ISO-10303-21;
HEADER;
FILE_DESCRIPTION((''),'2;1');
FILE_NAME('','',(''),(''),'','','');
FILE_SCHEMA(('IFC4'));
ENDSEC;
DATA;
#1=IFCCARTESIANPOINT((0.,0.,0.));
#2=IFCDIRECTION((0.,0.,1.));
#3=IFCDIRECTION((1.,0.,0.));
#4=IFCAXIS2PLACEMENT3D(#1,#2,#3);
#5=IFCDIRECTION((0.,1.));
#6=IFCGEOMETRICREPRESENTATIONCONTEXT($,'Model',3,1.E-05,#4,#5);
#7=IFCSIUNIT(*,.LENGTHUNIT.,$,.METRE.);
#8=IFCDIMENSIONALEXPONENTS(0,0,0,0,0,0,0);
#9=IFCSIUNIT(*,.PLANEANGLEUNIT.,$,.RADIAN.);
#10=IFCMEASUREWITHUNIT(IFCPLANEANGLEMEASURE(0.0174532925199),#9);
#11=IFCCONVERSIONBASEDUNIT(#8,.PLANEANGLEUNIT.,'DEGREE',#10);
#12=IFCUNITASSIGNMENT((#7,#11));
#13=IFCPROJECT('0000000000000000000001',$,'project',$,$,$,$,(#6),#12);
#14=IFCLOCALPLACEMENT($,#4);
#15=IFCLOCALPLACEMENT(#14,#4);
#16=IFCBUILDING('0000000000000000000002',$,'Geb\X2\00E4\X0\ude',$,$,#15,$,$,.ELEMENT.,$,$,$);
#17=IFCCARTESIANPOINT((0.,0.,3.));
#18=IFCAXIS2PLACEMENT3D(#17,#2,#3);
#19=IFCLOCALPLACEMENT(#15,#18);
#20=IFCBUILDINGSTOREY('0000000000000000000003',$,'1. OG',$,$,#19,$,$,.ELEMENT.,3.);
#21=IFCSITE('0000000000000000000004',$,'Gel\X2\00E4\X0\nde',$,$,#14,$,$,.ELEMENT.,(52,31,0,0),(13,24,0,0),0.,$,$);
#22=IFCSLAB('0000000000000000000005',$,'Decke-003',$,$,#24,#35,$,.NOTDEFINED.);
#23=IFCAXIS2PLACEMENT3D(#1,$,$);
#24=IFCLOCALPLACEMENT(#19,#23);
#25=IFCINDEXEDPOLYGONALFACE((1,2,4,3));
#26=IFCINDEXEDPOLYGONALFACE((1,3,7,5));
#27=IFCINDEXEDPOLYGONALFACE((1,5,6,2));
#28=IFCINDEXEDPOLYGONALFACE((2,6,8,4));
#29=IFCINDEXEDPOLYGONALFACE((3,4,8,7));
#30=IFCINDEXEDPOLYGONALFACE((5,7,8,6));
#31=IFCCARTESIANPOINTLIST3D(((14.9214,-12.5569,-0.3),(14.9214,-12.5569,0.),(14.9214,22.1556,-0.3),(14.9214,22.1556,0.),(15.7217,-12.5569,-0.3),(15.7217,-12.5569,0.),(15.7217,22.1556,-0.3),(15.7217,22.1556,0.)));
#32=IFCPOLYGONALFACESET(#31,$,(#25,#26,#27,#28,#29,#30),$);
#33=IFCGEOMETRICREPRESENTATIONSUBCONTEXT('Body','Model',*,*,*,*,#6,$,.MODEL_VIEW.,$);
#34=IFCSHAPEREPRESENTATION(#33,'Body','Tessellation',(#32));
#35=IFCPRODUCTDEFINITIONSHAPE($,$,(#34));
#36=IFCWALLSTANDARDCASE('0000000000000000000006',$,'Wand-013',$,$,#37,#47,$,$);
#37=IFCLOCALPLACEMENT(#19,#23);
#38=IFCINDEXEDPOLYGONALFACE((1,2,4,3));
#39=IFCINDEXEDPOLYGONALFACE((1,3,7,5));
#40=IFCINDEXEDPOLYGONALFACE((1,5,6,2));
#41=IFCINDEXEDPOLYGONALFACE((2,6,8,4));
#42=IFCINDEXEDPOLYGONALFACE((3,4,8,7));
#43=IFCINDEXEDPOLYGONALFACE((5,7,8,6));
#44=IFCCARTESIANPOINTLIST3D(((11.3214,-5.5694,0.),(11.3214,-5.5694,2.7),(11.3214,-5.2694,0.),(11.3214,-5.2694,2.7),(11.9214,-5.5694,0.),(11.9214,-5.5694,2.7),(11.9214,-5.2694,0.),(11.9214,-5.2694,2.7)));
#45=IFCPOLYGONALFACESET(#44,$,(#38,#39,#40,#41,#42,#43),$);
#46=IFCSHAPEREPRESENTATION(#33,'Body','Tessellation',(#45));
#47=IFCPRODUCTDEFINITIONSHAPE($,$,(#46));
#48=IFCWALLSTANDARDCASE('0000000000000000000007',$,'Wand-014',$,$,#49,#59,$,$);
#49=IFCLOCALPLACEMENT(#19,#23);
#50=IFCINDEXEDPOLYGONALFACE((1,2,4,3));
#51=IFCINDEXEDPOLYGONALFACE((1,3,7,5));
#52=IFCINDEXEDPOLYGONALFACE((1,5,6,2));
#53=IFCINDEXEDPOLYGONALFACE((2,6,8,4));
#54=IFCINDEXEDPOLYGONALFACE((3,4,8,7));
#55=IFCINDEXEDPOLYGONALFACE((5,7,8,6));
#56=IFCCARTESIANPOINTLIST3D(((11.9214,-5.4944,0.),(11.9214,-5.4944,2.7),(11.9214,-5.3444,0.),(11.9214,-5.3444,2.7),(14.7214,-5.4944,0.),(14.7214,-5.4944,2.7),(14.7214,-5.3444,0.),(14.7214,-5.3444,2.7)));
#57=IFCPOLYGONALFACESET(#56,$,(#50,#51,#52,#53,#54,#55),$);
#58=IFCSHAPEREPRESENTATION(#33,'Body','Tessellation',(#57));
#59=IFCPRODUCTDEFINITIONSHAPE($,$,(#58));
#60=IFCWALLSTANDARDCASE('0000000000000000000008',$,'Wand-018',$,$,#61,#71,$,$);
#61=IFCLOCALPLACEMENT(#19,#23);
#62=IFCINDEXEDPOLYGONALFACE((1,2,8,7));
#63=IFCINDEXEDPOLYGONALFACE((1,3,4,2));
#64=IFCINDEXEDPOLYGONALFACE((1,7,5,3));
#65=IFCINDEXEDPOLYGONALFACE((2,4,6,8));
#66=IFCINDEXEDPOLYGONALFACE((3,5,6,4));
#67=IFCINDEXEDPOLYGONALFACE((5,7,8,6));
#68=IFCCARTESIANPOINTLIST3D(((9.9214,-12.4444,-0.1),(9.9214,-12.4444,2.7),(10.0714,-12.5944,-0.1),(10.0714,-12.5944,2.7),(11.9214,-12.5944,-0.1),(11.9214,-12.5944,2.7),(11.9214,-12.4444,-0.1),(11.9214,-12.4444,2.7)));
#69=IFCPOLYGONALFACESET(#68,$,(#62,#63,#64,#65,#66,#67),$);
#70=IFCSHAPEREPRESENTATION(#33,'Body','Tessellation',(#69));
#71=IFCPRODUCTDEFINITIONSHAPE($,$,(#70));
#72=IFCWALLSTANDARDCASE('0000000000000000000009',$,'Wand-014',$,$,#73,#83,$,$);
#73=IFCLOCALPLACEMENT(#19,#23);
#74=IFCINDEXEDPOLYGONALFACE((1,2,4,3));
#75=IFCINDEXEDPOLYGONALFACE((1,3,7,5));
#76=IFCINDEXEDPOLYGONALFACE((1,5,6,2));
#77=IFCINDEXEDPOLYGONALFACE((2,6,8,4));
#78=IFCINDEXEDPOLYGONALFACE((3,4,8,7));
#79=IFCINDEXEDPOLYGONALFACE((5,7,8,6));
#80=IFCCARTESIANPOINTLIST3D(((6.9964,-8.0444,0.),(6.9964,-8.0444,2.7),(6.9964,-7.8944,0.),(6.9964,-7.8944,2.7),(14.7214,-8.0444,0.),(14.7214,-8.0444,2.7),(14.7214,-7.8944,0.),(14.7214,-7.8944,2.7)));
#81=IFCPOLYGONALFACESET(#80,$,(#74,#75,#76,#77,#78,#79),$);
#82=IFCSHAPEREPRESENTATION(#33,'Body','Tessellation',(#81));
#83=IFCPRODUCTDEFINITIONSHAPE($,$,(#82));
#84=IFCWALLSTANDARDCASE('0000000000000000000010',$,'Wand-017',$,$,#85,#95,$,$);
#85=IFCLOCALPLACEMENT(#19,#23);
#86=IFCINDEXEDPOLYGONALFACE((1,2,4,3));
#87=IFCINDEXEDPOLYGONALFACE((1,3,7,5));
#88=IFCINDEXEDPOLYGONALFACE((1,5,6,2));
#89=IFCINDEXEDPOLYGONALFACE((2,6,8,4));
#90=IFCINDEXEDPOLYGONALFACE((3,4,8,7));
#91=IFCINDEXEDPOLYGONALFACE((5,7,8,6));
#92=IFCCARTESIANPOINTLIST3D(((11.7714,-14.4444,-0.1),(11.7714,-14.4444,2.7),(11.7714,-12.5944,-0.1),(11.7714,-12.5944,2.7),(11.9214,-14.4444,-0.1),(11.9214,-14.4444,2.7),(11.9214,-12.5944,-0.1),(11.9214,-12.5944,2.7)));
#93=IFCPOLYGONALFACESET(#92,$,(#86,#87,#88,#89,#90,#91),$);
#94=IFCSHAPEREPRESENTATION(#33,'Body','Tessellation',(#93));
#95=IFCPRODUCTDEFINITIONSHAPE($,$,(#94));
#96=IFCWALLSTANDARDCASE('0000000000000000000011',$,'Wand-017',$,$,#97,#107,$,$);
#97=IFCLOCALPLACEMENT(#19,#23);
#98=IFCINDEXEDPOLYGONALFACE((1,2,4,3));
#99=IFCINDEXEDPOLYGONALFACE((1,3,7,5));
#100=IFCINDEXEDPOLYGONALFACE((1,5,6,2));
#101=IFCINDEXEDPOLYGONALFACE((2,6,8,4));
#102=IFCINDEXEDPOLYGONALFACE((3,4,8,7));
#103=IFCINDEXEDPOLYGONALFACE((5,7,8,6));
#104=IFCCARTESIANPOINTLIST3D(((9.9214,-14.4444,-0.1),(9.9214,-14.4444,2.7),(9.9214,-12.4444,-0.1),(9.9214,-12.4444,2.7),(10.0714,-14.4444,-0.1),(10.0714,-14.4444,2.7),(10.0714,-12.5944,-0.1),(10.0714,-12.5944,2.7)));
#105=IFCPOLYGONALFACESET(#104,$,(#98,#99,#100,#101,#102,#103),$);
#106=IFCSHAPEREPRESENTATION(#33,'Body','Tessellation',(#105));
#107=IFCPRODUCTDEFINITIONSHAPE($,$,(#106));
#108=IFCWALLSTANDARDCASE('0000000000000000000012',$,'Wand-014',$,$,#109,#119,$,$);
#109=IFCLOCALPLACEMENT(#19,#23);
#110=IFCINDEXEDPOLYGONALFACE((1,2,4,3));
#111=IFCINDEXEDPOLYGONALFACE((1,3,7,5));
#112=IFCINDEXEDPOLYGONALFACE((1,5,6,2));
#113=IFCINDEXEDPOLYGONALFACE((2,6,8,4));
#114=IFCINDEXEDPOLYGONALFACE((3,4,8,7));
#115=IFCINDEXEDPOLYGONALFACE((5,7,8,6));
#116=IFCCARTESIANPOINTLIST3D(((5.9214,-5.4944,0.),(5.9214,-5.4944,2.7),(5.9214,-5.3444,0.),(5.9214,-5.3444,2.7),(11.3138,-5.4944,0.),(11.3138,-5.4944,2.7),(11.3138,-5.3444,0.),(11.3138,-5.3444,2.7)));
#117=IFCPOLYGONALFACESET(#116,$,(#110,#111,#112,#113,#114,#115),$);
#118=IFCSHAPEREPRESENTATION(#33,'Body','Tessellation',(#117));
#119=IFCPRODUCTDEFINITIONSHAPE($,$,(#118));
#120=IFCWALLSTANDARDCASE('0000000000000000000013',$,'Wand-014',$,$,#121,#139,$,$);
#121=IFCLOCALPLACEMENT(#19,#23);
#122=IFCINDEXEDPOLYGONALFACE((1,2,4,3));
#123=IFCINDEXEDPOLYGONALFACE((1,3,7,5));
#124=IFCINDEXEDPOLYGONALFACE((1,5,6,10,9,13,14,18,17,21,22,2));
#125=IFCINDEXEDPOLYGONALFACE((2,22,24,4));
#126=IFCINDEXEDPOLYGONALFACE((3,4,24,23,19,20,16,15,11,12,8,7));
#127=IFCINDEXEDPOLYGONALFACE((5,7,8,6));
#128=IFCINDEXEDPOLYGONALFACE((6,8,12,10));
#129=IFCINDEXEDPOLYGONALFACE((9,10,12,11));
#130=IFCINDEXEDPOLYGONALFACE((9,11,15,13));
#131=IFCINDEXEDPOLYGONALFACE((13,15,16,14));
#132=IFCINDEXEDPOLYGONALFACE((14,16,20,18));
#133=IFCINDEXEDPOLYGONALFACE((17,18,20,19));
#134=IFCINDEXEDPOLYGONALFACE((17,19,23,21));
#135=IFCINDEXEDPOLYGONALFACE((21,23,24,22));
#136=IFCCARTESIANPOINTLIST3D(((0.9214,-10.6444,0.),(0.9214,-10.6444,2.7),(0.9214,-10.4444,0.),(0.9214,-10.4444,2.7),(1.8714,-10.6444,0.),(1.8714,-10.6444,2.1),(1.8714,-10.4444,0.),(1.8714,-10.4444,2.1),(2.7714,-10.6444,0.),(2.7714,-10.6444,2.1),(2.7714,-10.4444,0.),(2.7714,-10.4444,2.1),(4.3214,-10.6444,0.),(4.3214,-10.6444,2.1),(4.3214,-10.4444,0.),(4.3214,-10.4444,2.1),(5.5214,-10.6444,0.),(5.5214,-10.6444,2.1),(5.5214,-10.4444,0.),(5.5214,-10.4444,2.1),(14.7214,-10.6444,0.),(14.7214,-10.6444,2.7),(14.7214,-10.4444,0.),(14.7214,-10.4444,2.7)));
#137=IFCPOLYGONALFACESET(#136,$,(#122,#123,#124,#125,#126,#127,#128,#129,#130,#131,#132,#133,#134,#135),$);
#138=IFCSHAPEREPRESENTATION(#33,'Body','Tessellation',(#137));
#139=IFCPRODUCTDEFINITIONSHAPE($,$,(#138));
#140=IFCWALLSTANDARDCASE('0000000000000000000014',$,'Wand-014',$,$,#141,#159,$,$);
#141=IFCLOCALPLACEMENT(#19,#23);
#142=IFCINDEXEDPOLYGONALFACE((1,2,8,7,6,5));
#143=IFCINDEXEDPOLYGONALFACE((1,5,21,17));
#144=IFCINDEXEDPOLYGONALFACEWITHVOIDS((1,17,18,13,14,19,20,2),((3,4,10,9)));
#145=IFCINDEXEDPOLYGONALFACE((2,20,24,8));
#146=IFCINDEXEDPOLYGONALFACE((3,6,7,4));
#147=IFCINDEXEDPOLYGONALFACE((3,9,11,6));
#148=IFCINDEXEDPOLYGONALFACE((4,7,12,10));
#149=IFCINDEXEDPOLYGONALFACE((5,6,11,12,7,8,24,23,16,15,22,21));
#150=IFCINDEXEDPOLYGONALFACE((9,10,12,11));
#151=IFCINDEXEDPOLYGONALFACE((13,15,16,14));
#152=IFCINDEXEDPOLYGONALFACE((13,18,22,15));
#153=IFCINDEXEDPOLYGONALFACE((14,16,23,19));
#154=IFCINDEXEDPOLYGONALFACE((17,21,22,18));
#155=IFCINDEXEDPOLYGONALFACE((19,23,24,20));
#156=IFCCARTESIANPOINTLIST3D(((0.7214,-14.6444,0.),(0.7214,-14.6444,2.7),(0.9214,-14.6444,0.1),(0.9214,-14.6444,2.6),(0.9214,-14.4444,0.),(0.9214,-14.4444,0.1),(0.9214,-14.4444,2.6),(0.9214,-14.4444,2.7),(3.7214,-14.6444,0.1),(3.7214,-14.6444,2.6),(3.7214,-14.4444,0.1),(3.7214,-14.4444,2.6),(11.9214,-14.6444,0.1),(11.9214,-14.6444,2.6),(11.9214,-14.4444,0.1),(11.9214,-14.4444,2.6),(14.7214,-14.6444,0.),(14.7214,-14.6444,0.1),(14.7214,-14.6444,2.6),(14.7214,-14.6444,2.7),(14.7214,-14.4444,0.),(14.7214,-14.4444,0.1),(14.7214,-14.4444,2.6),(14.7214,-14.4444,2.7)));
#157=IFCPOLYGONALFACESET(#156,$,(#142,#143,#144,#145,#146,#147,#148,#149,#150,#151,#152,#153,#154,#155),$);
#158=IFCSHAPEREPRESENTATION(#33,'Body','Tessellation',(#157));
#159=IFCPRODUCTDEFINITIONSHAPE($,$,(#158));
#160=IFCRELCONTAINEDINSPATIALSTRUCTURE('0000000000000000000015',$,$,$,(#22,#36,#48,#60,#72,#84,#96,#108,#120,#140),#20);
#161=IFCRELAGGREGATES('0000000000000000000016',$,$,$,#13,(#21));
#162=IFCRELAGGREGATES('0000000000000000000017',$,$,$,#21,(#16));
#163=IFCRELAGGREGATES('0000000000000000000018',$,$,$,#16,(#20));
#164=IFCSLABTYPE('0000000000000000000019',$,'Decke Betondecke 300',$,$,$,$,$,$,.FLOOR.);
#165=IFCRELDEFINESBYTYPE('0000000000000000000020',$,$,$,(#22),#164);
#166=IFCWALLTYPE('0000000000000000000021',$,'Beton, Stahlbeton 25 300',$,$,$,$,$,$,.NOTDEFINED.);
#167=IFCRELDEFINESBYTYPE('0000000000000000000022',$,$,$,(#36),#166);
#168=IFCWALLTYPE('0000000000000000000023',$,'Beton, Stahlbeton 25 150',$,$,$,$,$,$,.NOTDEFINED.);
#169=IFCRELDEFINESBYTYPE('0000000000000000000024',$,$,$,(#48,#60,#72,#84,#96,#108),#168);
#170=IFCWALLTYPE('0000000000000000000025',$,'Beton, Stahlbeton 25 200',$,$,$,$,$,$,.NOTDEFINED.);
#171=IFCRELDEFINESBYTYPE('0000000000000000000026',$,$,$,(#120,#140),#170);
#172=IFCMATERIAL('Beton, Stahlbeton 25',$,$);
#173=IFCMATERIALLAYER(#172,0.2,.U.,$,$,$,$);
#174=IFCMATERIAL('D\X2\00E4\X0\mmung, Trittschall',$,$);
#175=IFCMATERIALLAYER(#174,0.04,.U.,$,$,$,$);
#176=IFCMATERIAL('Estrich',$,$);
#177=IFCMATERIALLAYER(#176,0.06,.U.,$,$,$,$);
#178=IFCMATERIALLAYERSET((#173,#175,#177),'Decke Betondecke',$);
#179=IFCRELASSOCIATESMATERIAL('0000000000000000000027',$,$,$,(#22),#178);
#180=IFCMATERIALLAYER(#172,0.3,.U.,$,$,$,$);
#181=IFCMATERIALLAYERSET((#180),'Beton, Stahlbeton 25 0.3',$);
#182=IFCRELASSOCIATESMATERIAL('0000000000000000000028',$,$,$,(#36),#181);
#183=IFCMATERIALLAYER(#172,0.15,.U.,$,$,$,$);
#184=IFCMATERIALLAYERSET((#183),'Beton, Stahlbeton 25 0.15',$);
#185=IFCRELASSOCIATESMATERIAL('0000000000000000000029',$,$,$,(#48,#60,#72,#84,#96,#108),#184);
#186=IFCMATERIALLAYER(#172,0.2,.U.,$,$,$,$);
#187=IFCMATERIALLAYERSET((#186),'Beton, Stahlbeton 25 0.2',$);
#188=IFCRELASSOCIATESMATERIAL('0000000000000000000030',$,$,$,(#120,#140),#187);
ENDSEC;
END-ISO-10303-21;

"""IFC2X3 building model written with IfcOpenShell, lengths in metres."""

from ifc_helpers import new_model, entity, si_unit, converted_unit, direction, frame, origin_with_axes, origin_2d_with_axis, place, context, subcontext, project, spatial, polyline, rectangle, outline, extrude, material, layer, layer_set, layer_usage, type_object, element, save


model = new_model("IFC2X3")

# Units and contexts
model_context = context("Model", 3, precision=1e-05, world=origin_with_axes(), true_north=direction((0.0, 1.0)))
body_context = subcontext(model_context, "Body", "Model", "MODEL_VIEW")
ifc_project = project(units=[si_unit("LENGTHUNIT", "METRE"), converted_unit("PLANEANGLEUNIT", "DEGREE", entity("IfcPlaneAngleMeasure", 0.0174532925199), si_unit("PLANEANGLEUNIT", "RADIAN"), dimensions=[0, 0, 0, 0, 0, 0, 0])], contexts=[model_context])

# Site, building, storey
site_placement = place(None, origin_with_axes())
site = spatial("IfcSite", under=ifc_project, at=site_placement, Name="Gelände", CompositionType="ELEMENT", RefLatitude=(52, 31, 0, 0), RefLongitude=(13, 24, 0, 0), RefElevation=0.0)
building_placement = place(site_placement, origin_with_axes())
building = spatial("IfcBuilding", under=site, at=building_placement, Name="Gebäude", CompositionType="ELEMENT")
storey_placement = place(building_placement, frame((0.0, 0.0, 3.0), z_axis=(0.0, 0.0, 1.0), x_axis=(1.0, 0.0, 0.0)))
storey = spatial("IfcBuildingStorey", under=building, at=storey_placement, Name="1. OG", CompositionType="ELEMENT", Elevation=3.0)

# Slab
ifc_material_1 = material(Name="Beton, Stahlbeton 25")
ifc_layer_1 = layer(ifc_material_1, 0.2, ventilated="UNKNOWN")
ifc_material_2 = material(Name="Dämmung, Trittschall")
ifc_layer_2 = layer(ifc_material_2, 0.04, ventilated="UNKNOWN")
ifc_material_3 = material(Name="Estrich")
ifc_layer_3 = layer(ifc_material_3, 0.06, ventilated="UNKNOWN")
ifc_layer_set_1 = layer_set([ifc_layer_1, ifc_layer_2, ifc_layer_3], Name="Decke Betondecke")
ifc_layer_usage_1 = layer_usage(ifc_layer_set_1, "AXIS3", "NEGATIVE", 0.3)
slab_type = type_object("IfcSlabType", Name="Decke Betondecke 300", PredefinedType="FLOOR")
slab_placement = place(storey_placement, frame((14.9214, -12.5569, 0.0), z_axis=(0.0, 0.0, 1.0), x_axis=(1.0, 0.0, 0.0)))
element("IfcSlab", 1, at=slab_placement, inside=storey, type_object=slab_type, material=ifc_layer_usage_1, Name="Decke-003", PredefinedType="NOTDEFINED", context=body_context, shape_type="SweptSolid", body=[
    extrude(outline(polyline([(0.0, 0.0), (0.8003, 0.0), (0.8003, 34.7125), (0.0, 34.7125), (0.0, 0.0)])), frame((0.0, 0.0, -0.3), z_axis=(0.0, 0.0, 1.0), x_axis=(1.0, 0.0, 0.0)), (0.0, 0.0, 1.0), 0.3),
])

# Walls
ifc_layer_4 = layer(ifc_material_1, 0.3, ventilated="UNKNOWN")
ifc_layer_set_2 = layer_set([ifc_layer_4], Name="Beton, Stahlbeton 25 0.3")
ifc_layer_usage_2 = layer_usage(ifc_layer_set_2, "AXIS2", "NEGATIVE", 0.3)
wall_type_1 = type_object("IfcWallType", Name="Beton, Stahlbeton 25 300", PredefinedType="NOTDEFINED")
wall_1_placement = place(storey_placement, frame((11.3214, -5.5694, 0.0), z_axis=(0.0, 0.0, 1.0), x_axis=(1.0, 0.0, 0.0)))
element("IfcWallStandardCase", 2, at=wall_1_placement, inside=storey, type_object=wall_type_1, material=ifc_layer_usage_2, Name="Wand-013", context=body_context, shape_type="SweptSolid", body=[
    extrude(outline(polyline([(0.0, 0.0), (0.6, 0.0), (0.6, 0.3), (0.0, 0.3), (0.0, 0.0)])), origin_with_axes(), (0.0, 0.0, 1.0), 2.7),
])
ifc_layer_5 = layer(ifc_material_1, 0.15, ventilated="UNKNOWN")
ifc_layer_set_3 = layer_set([ifc_layer_5], Name="Beton, Stahlbeton 25 0.15")
ifc_layer_usage_3 = layer_usage(ifc_layer_set_3, "AXIS2", "NEGATIVE", 0.075)
wall_type_2 = type_object("IfcWallType", Name="Beton, Stahlbeton 25 150", PredefinedType="NOTDEFINED")
wall_2_placement = place(storey_placement, frame((14.7214, -5.4194, 0.0), z_axis=(0.0, 0.0, 1.0), x_axis=(-1.0, 0.0, 0.0)))
element("IfcWallStandardCase", 3, at=wall_2_placement, inside=storey, type_object=wall_type_2, material=ifc_layer_usage_3, Name="Wand-014", context=body_context, shape_type="SweptSolid", body=[
    extrude(outline(polyline([(0.0, -0.075), (2.8, -0.075), (2.8, 0.075), (0.0, 0.075), (0.0, -0.075)])), origin_with_axes(), (0.0, 0.0, 1.0), 2.7),
])
ifc_layer_usage_4 = layer_usage(ifc_layer_set_3, "AXIS2", "NEGATIVE", 0.0)
wall_3_placement = place(storey_placement, frame((11.9214, -12.5944, -0.1), z_axis=(0.0, 0.0, 1.0), x_axis=(-1.0, 0.0, 0.0)))
element("IfcWallStandardCase", 4, at=wall_3_placement, inside=storey, type_object=wall_type_2, material=ifc_layer_usage_4, Name="Wand-018", context=body_context, shape_type="SweptSolid", body=[
    extrude(outline(polyline([(0.0, -0.15), (2.0, -0.15), (1.85, 0.0), (0.0, 0.0), (0.0, -0.15)])), origin_with_axes(), (0.0, 0.0, 1.0), 2.8),
])
ifc_layer_usage_5 = layer_usage(ifc_layer_set_3, "AXIS2", "NEGATIVE", 0.075)
wall_4_placement = place(storey_placement, frame((14.7214, -7.9694, 0.0), z_axis=(0.0, 0.0, 1.0), x_axis=(-1.0, 0.0, 0.0)))
element("IfcWallStandardCase", 5, at=wall_4_placement, inside=storey, type_object=wall_type_2, material=ifc_layer_usage_5, Name="Wand-014", context=body_context, shape_type="SweptSolid", body=[
    extrude(outline(polyline([(0.0, -0.075), (7.725, -0.075), (7.725, 0.075), (0.0, 0.075), (0.0, -0.075)])), origin_with_axes(), (0.0, 0.0, 1.0), 2.7),
])
ifc_layer_usage_6 = layer_usage(ifc_layer_set_3, "AXIS2", "NEGATIVE", 0.0)
wall_5_placement = place(storey_placement, frame((11.7714, -14.4444, -0.1), z_axis=(0.0, 0.0, 1.0), x_axis=(0.0, 1.0, 0.0)))
element("IfcWallStandardCase", 6, at=wall_5_placement, inside=storey, type_object=wall_type_2, material=ifc_layer_usage_6, Name="Wand-017", context=body_context, shape_type="SweptSolid", body=[
    extrude(outline(polyline([(0.0, -0.15), (1.85, -0.15), (1.85, 0.0), (0.0, 0.0), (0.0, -0.15)])), origin_with_axes(), (0.0, 0.0, 1.0), 2.8),
])
ifc_layer_usage_7 = layer_usage(ifc_layer_set_3, "AXIS2", "NEGATIVE", 0.0)
wall_6_placement = place(storey_placement, frame((9.9214, -14.4444, -0.1), z_axis=(0.0, 0.0, 1.0), x_axis=(0.0, 1.0, 0.0)))
element("IfcWallStandardCase", 7, at=wall_6_placement, inside=storey, type_object=wall_type_2, material=ifc_layer_usage_7, Name="Wand-017", context=body_context, shape_type="SweptSolid", body=[
    extrude(outline(polyline([(0.0, -0.15), (1.85, -0.15), (2.0, 0.0), (0.0, 0.0), (0.0, -0.15)])), origin_with_axes(), (0.0, 0.0, 1.0), 2.8),
])
ifc_layer_usage_8 = layer_usage(ifc_layer_set_3, "AXIS2", "NEGATIVE", 0.075)
wall_7_placement = place(storey_placement, frame((11.3138, -5.4194, 0.0), z_axis=(0.0, 0.0, 1.0), x_axis=(-1.0, 0.0, 0.0)))
element("IfcWallStandardCase", 8, at=wall_7_placement, inside=storey, type_object=wall_type_2, material=ifc_layer_usage_8, Name="Wand-014", context=body_context, shape_type="SweptSolid", body=[
    extrude(outline(polyline([(0.0, -0.075), (5.3924, -0.075), (5.3924, 0.075), (0.0, 0.075), (0.0, -0.075)])), origin_with_axes(), (0.0, 0.0, 1.0), 2.7),
])

# Walls, openings
ifc_layer_6 = layer(ifc_material_1, 0.2, ventilated="UNKNOWN")
ifc_layer_set_4 = layer_set([ifc_layer_6], Name="Beton, Stahlbeton 25 0.2")
ifc_layer_usage_9 = layer_usage(ifc_layer_set_4, "AXIS2", "POSITIVE", 0.0)
wall_type_3 = type_object("IfcWallType", Name="Beton, Stahlbeton 25 200", PredefinedType="NOTDEFINED")
wall_8_placement = place(storey_placement, frame((14.7214, -10.4444, 0.0), z_axis=(0.0, 0.0, 1.0), x_axis=(-1.0, 0.0, 0.0)))
wall_8 = element("IfcWallStandardCase", 9, at=wall_8_placement, inside=storey, type_object=wall_type_3, material=ifc_layer_usage_9, Name="Wand-014", context=body_context, shape_type="SweptSolid", body=[
    extrude(outline(polyline([(0.0, 0.0), (13.8, 0.0), (13.8, 0.2), (0.0, 0.2), (0.0, 0.0)])), origin_with_axes(), (0.0, 0.0, 1.0), 2.7),
])
opening_1_placement = place(wall_8_placement, frame((12.4, 0.0, 0.0), z_axis=(0.0, 0.0, 1.0), x_axis=(1.0, 0.0, 0.0)))
element("IfcOpeningElement", 10, at=opening_1_placement, cuts=wall_8, context=body_context, shape_type="SweptSolid", body=[
    extrude(rectangle(XDim=0.9, YDim=2.1, at=origin_2d_with_axis()), frame((0.0, 0.4, 1.05), z_axis=(0.0, -1.0, 0.0), x_axis=(1.0, 0.0, 0.0)), (0.0, 0.0, 1.0), 0.2),
    extrude(rectangle(XDim=0.9, YDim=2.1, at=origin_2d_with_axis()), frame((0.0, 0.0, 1.05), z_axis=(0.0, 1.0, 0.0), x_axis=(1.0, 0.0, 0.0)), (0.0, 0.0, 1.0), 0.2),
])
opening_2_placement = place(wall_8_placement, frame((9.8, 0.0, 0.0), z_axis=(0.0, 0.0, 1.0), x_axis=(1.0, 0.0, 0.0)))
element("IfcOpeningElement", 11, at=opening_2_placement, cuts=wall_8, context=body_context, shape_type="SweptSolid", body=[
    extrude(rectangle(XDim=1.2, YDim=2.1, at=origin_2d_with_axis()), frame((0.0, 0.4, 1.05), z_axis=(0.0, -1.0, 0.0), x_axis=(1.0, 0.0, 0.0)), (0.0, 0.0, 1.0), 0.2),
    extrude(rectangle(XDim=1.2, YDim=2.1, at=origin_2d_with_axis()), frame((0.0, 0.0, 1.05), z_axis=(0.0, 1.0, 0.0), x_axis=(1.0, 0.0, 0.0)), (0.0, 0.0, 1.0), 0.2),
])
ifc_layer_usage_10 = layer_usage(ifc_layer_set_4, "AXIS2", "POSITIVE", 0.0)
wall_9_placement = place(storey_placement, frame((14.7214, -14.4444, 0.0), z_axis=(0.0, 0.0, 1.0), x_axis=(-1.0, 0.0, 0.0)))
wall_9 = element("IfcWallStandardCase", 12, at=wall_9_placement, inside=storey, type_object=wall_type_3, material=ifc_layer_usage_10, Name="Wand-014", context=body_context, shape_type="SweptSolid", body=[
    extrude(outline(polyline([(0.0, 0.0), (13.8, 0.0), (14.0, 0.2), (0.0, 0.2), (0.0, 0.0)])), origin_with_axes(), (0.0, 0.0, 1.0), 2.7),
])
opening_3_placement = place(wall_9_placement, frame((12.4, 0.0, 0.1), z_axis=(0.0, 0.0, 1.0), x_axis=(1.0, 0.0, 0.0)))
element("IfcOpeningElement", 13, at=opening_3_placement, cuts=wall_9, context=body_context, shape_type="SweptSolid", body=[
    extrude(rectangle(XDim=2.8, YDim=2.5, at=origin_2d_with_axis()), frame((0.0, 0.4, 1.25), z_axis=(0.0, -1.0, 0.0), x_axis=(1.0, 0.0, 0.0)), (0.0, 0.0, 1.0), 0.2),
    extrude(rectangle(XDim=2.8, YDim=2.5, at=origin_2d_with_axis()), frame((0.0, 0.0, 1.25), z_axis=(0.0, 1.0, 0.0), x_axis=(1.0, 0.0, 0.0)), (0.0, 0.0, 1.0), 0.2),
])
opening_4_placement = place(wall_9_placement, frame((1.4, 0.0, 0.1), z_axis=(0.0, 0.0, 1.0), x_axis=(1.0, 0.0, 0.0)))
element("IfcOpeningElement", 14, at=opening_4_placement, cuts=wall_9, context=body_context, shape_type="SweptSolid", body=[
    extrude(rectangle(XDim=2.8, YDim=2.5, at=origin_2d_with_axis()), frame((0.0, 0.4, 1.25), z_axis=(0.0, -1.0, 0.0), x_axis=(1.0, 0.0, 0.0)), (0.0, 0.0, 1.0), 0.2),
    extrude(rectangle(XDim=2.8, YDim=2.5, at=origin_2d_with_axis()), frame((0.0, 0.0, 1.25), z_axis=(0.0, 1.0, 0.0), x_axis=(1.0, 0.0, 0.0)), (0.0, 0.0, 1.0), 0.2),
])

save(model, "model.ifc")
